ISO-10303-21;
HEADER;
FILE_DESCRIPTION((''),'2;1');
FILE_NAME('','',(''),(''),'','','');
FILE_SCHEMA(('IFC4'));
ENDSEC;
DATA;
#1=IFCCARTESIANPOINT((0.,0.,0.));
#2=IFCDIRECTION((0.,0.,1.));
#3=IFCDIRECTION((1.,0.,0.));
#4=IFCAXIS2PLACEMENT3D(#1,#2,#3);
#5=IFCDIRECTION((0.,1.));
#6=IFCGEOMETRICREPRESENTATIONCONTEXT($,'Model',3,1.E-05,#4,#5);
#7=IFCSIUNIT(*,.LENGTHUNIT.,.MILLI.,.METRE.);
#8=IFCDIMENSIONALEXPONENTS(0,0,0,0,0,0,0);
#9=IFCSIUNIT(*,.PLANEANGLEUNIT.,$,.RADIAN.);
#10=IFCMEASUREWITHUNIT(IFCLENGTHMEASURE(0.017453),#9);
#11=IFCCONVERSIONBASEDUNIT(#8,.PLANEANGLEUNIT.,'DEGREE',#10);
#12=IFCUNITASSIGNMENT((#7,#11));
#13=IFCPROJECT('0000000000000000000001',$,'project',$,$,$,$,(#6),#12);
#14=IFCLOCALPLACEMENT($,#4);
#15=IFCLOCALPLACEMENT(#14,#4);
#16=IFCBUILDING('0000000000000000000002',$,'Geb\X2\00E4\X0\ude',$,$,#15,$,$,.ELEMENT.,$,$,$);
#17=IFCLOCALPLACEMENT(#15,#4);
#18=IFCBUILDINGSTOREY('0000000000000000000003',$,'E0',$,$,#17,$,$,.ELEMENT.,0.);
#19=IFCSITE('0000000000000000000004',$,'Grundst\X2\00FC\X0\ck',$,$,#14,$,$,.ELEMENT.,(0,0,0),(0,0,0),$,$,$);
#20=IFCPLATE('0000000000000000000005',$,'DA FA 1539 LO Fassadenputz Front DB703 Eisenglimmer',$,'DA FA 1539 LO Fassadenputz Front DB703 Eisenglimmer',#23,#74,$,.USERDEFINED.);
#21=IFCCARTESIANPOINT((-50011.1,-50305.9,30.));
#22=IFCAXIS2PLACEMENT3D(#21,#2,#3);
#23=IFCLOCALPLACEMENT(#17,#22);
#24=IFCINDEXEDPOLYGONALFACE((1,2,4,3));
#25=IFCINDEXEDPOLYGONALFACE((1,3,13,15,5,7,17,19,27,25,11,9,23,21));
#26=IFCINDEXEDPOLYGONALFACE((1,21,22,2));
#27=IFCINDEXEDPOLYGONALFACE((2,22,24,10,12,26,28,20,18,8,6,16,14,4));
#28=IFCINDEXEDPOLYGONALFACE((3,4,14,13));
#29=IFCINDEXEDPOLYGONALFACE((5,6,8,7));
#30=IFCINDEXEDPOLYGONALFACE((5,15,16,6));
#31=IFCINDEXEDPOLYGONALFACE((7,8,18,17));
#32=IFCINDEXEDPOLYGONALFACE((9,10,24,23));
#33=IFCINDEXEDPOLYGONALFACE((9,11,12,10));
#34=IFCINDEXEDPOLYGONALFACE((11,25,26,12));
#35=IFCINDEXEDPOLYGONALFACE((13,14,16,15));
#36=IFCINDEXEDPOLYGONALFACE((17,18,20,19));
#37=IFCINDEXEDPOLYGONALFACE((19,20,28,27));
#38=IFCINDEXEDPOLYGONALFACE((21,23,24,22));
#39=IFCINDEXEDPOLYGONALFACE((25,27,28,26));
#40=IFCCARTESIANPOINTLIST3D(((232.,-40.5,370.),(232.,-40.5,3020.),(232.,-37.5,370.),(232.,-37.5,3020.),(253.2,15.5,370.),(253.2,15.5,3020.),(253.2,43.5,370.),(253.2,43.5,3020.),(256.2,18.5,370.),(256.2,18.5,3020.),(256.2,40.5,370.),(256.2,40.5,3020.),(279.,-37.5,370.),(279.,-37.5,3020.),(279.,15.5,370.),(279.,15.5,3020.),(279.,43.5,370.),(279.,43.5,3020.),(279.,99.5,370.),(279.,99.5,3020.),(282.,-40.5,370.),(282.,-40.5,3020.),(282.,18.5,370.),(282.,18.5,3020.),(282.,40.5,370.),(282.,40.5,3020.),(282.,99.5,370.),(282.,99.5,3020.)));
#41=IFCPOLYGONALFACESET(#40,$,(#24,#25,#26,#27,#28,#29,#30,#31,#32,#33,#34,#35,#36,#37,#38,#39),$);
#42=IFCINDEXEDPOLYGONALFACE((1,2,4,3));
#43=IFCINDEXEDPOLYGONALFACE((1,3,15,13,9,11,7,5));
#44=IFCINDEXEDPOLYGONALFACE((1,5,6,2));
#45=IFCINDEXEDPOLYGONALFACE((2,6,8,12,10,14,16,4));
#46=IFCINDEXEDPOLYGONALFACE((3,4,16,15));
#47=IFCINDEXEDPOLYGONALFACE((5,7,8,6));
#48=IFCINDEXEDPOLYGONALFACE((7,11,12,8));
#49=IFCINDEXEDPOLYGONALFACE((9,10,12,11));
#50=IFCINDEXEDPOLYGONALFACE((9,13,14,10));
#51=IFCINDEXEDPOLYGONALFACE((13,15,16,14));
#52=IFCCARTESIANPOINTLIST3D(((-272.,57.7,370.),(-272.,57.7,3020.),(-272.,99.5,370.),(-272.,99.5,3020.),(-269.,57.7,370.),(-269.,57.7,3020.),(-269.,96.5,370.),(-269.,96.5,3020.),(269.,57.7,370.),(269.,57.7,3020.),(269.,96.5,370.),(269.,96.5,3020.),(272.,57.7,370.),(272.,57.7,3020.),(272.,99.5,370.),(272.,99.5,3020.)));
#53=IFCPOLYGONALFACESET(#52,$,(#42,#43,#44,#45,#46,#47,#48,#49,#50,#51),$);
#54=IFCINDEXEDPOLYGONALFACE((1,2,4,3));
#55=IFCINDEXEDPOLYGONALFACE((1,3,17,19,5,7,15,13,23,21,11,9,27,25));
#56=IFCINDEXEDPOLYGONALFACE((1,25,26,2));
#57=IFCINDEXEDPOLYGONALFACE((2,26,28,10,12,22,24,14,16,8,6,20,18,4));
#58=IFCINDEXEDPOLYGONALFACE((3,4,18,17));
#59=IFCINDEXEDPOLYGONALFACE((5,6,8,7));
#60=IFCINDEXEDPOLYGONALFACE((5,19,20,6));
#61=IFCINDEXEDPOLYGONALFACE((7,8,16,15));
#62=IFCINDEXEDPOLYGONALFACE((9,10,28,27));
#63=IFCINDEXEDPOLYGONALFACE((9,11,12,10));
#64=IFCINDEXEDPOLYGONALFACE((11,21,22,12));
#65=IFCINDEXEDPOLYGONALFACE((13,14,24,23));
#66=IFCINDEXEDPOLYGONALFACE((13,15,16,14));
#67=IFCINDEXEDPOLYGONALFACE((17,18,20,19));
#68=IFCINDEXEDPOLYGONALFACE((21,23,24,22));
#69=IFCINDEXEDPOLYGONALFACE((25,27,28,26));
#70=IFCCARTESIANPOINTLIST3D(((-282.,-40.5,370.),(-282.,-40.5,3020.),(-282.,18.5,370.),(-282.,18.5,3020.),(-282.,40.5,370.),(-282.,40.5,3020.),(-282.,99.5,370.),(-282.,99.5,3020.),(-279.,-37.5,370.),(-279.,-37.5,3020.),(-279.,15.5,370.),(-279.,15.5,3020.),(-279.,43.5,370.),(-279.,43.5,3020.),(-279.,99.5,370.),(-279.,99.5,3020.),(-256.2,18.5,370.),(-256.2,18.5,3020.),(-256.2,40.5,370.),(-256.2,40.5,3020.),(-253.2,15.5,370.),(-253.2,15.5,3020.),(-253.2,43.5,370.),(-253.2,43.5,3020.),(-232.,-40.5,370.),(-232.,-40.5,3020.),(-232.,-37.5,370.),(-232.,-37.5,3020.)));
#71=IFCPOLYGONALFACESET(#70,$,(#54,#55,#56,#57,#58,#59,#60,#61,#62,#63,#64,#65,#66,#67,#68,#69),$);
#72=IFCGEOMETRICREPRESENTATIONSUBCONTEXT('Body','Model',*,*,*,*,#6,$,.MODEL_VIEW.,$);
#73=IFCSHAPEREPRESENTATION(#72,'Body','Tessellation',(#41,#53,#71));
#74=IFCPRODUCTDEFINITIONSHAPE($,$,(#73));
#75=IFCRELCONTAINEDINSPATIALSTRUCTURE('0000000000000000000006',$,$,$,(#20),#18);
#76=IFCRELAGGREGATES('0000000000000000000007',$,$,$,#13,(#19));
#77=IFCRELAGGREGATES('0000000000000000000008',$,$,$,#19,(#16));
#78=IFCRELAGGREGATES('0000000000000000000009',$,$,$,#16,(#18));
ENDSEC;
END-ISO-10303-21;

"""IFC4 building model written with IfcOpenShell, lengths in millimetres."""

from ifc_helpers import new_model, entity, si_unit, converted_unit, direction, frame, origin_with_axes, place, context, subcontext, project, spatial, line, indexed_curve, outline, extrude, source, transform, mapped, element, save


model = new_model("IFC4")

# Units and contexts
model_context = context("Model", 3, precision=1e-05, world=origin_with_axes(), true_north=direction((0.0, 1.0)))
body_context = subcontext(model_context, "Body", "Model", "MODEL_VIEW")
ifc_project = project(units=[si_unit("LENGTHUNIT", "METRE", prefix="MILLI"), converted_unit("PLANEANGLEUNIT", "DEGREE", entity("IfcLengthMeasure", 0.017453), si_unit("PLANEANGLEUNIT", "RADIAN"), dimensions=[0, 0, 0, 0, 0, 0, 0])], contexts=[model_context])

# Site, building, storey
site_placement = place(None, origin_with_axes())
site = spatial("IfcSite", under=ifc_project, at=site_placement, Name="Grundstück", CompositionType="ELEMENT", RefLatitude=(0, 0, 0), RefLongitude=(0, 0, 0))
building_placement = place(site_placement, origin_with_axes())
building = spatial("IfcBuilding", under=site, at=building_placement, Name="Gebäude", CompositionType="ELEMENT")
storey_placement = place(building_placement, origin_with_axes())
storey = spatial("IfcBuildingStorey", under=building, at=storey_placement, Name="E0", CompositionType="ELEMENT", Elevation=0.0)

# Plate
shared_shape_1 = source(origin_with_axes(), body_context, "Body", "SweptSolid", [
    extrude(outline(indexed_curve([(282.0, 99.5), (282.0, 40.5), (256.2, 40.5), (256.2, 18.5), (282.0, 18.5), (282.0, -40.5), (232.0, -40.5), (232.0, -37.5), (279.0, -37.5), (279.0, 15.5), (253.2, 15.5), (253.2, 43.5), (279.0, 43.5), (279.0, 99.5)], segments=[line(1, 2), line(2, 3), line(3, 4), line(4, 5), line(5, 6), line(6, 7), line(7, 8), line(8, 9), line(9, 10), line(10, 11), line(11, 12), line(12, 13), line(13, 14), line(14, 1)])), frame((0.0, 0.0, 370.0), z_axis=(0.0, 0.0, 1.0), x_axis=(1.0, 0.0, 0.0)), (0.0, 0.0, 1.0), 2650.0),
    extrude(outline(indexed_curve([(272.0, 99.5), (272.0, 57.7), (269.0, 57.7), (269.0, 96.5), (-269.0, 96.5), (-269.0, 57.7), (-272.0, 57.7), (-272.0, 99.5)], segments=[line(1, 2), line(2, 3), line(3, 4), line(4, 5), line(5, 6), line(6, 7), line(7, 8), line(8, 1)])), frame((0.0, 0.0, 370.0), z_axis=(0.0, 0.0, 1.0), x_axis=(1.0, 0.0, 0.0)), (0.0, 0.0, 1.0), 2650.0),
    extrude(outline(indexed_curve([(-282.0, 99.5), (-282.0, 40.5), (-256.2, 40.5), (-256.2, 18.5), (-282.0, 18.5), (-282.0, -40.5), (-232.0, -40.5), (-232.0, -37.5), (-279.0, -37.5), (-279.0, 15.5), (-253.2, 15.5), (-253.2, 43.5), (-279.0, 43.5), (-279.0, 99.5)], segments=[line(1, 2), line(2, 3), line(3, 4), line(4, 5), line(5, 6), line(6, 7), line(7, 8), line(8, 9), line(9, 10), line(10, 11), line(11, 12), line(12, 13), line(13, 14), line(14, 1)])), frame((0.0, 0.0, 370.0), z_axis=(0.0, 0.0, 1.0), x_axis=(1.0, 0.0, 0.0)), (0.0, 0.0, 1.0), 2650.0),
])
for number, where, z_axis, x_axis, name in (
    (1, (-50011.1, -50305.9, 30.0), (0.0, 0.0, 1.0), (1.0, 0.0, 0.0), "DA FA 1539 LO Fassadenputz Front DB703 Eisenglimmer"),
):
    element("IfcPlate", number, at=place(storey_placement, frame(where, z_axis=z_axis, x_axis=x_axis)), inside=storey, Name=name, ObjectType="DA FA 1539 LO Fassadenputz Front DB703 Eisenglimmer", PredefinedType="USERDEFINED", context=body_context, shape_type="MappedRepresentation", body=[
        mapped(shared_shape_1, transform((0.0, 0.0, 0.0), x_axis=(1.0, 0.0, 0.0), y_axis=(0.0, 1.0, 0.0), z_axis=(0.0, 0.0, 1.0), scale=1.0)),
    ])

save(model, "model.ifc")
